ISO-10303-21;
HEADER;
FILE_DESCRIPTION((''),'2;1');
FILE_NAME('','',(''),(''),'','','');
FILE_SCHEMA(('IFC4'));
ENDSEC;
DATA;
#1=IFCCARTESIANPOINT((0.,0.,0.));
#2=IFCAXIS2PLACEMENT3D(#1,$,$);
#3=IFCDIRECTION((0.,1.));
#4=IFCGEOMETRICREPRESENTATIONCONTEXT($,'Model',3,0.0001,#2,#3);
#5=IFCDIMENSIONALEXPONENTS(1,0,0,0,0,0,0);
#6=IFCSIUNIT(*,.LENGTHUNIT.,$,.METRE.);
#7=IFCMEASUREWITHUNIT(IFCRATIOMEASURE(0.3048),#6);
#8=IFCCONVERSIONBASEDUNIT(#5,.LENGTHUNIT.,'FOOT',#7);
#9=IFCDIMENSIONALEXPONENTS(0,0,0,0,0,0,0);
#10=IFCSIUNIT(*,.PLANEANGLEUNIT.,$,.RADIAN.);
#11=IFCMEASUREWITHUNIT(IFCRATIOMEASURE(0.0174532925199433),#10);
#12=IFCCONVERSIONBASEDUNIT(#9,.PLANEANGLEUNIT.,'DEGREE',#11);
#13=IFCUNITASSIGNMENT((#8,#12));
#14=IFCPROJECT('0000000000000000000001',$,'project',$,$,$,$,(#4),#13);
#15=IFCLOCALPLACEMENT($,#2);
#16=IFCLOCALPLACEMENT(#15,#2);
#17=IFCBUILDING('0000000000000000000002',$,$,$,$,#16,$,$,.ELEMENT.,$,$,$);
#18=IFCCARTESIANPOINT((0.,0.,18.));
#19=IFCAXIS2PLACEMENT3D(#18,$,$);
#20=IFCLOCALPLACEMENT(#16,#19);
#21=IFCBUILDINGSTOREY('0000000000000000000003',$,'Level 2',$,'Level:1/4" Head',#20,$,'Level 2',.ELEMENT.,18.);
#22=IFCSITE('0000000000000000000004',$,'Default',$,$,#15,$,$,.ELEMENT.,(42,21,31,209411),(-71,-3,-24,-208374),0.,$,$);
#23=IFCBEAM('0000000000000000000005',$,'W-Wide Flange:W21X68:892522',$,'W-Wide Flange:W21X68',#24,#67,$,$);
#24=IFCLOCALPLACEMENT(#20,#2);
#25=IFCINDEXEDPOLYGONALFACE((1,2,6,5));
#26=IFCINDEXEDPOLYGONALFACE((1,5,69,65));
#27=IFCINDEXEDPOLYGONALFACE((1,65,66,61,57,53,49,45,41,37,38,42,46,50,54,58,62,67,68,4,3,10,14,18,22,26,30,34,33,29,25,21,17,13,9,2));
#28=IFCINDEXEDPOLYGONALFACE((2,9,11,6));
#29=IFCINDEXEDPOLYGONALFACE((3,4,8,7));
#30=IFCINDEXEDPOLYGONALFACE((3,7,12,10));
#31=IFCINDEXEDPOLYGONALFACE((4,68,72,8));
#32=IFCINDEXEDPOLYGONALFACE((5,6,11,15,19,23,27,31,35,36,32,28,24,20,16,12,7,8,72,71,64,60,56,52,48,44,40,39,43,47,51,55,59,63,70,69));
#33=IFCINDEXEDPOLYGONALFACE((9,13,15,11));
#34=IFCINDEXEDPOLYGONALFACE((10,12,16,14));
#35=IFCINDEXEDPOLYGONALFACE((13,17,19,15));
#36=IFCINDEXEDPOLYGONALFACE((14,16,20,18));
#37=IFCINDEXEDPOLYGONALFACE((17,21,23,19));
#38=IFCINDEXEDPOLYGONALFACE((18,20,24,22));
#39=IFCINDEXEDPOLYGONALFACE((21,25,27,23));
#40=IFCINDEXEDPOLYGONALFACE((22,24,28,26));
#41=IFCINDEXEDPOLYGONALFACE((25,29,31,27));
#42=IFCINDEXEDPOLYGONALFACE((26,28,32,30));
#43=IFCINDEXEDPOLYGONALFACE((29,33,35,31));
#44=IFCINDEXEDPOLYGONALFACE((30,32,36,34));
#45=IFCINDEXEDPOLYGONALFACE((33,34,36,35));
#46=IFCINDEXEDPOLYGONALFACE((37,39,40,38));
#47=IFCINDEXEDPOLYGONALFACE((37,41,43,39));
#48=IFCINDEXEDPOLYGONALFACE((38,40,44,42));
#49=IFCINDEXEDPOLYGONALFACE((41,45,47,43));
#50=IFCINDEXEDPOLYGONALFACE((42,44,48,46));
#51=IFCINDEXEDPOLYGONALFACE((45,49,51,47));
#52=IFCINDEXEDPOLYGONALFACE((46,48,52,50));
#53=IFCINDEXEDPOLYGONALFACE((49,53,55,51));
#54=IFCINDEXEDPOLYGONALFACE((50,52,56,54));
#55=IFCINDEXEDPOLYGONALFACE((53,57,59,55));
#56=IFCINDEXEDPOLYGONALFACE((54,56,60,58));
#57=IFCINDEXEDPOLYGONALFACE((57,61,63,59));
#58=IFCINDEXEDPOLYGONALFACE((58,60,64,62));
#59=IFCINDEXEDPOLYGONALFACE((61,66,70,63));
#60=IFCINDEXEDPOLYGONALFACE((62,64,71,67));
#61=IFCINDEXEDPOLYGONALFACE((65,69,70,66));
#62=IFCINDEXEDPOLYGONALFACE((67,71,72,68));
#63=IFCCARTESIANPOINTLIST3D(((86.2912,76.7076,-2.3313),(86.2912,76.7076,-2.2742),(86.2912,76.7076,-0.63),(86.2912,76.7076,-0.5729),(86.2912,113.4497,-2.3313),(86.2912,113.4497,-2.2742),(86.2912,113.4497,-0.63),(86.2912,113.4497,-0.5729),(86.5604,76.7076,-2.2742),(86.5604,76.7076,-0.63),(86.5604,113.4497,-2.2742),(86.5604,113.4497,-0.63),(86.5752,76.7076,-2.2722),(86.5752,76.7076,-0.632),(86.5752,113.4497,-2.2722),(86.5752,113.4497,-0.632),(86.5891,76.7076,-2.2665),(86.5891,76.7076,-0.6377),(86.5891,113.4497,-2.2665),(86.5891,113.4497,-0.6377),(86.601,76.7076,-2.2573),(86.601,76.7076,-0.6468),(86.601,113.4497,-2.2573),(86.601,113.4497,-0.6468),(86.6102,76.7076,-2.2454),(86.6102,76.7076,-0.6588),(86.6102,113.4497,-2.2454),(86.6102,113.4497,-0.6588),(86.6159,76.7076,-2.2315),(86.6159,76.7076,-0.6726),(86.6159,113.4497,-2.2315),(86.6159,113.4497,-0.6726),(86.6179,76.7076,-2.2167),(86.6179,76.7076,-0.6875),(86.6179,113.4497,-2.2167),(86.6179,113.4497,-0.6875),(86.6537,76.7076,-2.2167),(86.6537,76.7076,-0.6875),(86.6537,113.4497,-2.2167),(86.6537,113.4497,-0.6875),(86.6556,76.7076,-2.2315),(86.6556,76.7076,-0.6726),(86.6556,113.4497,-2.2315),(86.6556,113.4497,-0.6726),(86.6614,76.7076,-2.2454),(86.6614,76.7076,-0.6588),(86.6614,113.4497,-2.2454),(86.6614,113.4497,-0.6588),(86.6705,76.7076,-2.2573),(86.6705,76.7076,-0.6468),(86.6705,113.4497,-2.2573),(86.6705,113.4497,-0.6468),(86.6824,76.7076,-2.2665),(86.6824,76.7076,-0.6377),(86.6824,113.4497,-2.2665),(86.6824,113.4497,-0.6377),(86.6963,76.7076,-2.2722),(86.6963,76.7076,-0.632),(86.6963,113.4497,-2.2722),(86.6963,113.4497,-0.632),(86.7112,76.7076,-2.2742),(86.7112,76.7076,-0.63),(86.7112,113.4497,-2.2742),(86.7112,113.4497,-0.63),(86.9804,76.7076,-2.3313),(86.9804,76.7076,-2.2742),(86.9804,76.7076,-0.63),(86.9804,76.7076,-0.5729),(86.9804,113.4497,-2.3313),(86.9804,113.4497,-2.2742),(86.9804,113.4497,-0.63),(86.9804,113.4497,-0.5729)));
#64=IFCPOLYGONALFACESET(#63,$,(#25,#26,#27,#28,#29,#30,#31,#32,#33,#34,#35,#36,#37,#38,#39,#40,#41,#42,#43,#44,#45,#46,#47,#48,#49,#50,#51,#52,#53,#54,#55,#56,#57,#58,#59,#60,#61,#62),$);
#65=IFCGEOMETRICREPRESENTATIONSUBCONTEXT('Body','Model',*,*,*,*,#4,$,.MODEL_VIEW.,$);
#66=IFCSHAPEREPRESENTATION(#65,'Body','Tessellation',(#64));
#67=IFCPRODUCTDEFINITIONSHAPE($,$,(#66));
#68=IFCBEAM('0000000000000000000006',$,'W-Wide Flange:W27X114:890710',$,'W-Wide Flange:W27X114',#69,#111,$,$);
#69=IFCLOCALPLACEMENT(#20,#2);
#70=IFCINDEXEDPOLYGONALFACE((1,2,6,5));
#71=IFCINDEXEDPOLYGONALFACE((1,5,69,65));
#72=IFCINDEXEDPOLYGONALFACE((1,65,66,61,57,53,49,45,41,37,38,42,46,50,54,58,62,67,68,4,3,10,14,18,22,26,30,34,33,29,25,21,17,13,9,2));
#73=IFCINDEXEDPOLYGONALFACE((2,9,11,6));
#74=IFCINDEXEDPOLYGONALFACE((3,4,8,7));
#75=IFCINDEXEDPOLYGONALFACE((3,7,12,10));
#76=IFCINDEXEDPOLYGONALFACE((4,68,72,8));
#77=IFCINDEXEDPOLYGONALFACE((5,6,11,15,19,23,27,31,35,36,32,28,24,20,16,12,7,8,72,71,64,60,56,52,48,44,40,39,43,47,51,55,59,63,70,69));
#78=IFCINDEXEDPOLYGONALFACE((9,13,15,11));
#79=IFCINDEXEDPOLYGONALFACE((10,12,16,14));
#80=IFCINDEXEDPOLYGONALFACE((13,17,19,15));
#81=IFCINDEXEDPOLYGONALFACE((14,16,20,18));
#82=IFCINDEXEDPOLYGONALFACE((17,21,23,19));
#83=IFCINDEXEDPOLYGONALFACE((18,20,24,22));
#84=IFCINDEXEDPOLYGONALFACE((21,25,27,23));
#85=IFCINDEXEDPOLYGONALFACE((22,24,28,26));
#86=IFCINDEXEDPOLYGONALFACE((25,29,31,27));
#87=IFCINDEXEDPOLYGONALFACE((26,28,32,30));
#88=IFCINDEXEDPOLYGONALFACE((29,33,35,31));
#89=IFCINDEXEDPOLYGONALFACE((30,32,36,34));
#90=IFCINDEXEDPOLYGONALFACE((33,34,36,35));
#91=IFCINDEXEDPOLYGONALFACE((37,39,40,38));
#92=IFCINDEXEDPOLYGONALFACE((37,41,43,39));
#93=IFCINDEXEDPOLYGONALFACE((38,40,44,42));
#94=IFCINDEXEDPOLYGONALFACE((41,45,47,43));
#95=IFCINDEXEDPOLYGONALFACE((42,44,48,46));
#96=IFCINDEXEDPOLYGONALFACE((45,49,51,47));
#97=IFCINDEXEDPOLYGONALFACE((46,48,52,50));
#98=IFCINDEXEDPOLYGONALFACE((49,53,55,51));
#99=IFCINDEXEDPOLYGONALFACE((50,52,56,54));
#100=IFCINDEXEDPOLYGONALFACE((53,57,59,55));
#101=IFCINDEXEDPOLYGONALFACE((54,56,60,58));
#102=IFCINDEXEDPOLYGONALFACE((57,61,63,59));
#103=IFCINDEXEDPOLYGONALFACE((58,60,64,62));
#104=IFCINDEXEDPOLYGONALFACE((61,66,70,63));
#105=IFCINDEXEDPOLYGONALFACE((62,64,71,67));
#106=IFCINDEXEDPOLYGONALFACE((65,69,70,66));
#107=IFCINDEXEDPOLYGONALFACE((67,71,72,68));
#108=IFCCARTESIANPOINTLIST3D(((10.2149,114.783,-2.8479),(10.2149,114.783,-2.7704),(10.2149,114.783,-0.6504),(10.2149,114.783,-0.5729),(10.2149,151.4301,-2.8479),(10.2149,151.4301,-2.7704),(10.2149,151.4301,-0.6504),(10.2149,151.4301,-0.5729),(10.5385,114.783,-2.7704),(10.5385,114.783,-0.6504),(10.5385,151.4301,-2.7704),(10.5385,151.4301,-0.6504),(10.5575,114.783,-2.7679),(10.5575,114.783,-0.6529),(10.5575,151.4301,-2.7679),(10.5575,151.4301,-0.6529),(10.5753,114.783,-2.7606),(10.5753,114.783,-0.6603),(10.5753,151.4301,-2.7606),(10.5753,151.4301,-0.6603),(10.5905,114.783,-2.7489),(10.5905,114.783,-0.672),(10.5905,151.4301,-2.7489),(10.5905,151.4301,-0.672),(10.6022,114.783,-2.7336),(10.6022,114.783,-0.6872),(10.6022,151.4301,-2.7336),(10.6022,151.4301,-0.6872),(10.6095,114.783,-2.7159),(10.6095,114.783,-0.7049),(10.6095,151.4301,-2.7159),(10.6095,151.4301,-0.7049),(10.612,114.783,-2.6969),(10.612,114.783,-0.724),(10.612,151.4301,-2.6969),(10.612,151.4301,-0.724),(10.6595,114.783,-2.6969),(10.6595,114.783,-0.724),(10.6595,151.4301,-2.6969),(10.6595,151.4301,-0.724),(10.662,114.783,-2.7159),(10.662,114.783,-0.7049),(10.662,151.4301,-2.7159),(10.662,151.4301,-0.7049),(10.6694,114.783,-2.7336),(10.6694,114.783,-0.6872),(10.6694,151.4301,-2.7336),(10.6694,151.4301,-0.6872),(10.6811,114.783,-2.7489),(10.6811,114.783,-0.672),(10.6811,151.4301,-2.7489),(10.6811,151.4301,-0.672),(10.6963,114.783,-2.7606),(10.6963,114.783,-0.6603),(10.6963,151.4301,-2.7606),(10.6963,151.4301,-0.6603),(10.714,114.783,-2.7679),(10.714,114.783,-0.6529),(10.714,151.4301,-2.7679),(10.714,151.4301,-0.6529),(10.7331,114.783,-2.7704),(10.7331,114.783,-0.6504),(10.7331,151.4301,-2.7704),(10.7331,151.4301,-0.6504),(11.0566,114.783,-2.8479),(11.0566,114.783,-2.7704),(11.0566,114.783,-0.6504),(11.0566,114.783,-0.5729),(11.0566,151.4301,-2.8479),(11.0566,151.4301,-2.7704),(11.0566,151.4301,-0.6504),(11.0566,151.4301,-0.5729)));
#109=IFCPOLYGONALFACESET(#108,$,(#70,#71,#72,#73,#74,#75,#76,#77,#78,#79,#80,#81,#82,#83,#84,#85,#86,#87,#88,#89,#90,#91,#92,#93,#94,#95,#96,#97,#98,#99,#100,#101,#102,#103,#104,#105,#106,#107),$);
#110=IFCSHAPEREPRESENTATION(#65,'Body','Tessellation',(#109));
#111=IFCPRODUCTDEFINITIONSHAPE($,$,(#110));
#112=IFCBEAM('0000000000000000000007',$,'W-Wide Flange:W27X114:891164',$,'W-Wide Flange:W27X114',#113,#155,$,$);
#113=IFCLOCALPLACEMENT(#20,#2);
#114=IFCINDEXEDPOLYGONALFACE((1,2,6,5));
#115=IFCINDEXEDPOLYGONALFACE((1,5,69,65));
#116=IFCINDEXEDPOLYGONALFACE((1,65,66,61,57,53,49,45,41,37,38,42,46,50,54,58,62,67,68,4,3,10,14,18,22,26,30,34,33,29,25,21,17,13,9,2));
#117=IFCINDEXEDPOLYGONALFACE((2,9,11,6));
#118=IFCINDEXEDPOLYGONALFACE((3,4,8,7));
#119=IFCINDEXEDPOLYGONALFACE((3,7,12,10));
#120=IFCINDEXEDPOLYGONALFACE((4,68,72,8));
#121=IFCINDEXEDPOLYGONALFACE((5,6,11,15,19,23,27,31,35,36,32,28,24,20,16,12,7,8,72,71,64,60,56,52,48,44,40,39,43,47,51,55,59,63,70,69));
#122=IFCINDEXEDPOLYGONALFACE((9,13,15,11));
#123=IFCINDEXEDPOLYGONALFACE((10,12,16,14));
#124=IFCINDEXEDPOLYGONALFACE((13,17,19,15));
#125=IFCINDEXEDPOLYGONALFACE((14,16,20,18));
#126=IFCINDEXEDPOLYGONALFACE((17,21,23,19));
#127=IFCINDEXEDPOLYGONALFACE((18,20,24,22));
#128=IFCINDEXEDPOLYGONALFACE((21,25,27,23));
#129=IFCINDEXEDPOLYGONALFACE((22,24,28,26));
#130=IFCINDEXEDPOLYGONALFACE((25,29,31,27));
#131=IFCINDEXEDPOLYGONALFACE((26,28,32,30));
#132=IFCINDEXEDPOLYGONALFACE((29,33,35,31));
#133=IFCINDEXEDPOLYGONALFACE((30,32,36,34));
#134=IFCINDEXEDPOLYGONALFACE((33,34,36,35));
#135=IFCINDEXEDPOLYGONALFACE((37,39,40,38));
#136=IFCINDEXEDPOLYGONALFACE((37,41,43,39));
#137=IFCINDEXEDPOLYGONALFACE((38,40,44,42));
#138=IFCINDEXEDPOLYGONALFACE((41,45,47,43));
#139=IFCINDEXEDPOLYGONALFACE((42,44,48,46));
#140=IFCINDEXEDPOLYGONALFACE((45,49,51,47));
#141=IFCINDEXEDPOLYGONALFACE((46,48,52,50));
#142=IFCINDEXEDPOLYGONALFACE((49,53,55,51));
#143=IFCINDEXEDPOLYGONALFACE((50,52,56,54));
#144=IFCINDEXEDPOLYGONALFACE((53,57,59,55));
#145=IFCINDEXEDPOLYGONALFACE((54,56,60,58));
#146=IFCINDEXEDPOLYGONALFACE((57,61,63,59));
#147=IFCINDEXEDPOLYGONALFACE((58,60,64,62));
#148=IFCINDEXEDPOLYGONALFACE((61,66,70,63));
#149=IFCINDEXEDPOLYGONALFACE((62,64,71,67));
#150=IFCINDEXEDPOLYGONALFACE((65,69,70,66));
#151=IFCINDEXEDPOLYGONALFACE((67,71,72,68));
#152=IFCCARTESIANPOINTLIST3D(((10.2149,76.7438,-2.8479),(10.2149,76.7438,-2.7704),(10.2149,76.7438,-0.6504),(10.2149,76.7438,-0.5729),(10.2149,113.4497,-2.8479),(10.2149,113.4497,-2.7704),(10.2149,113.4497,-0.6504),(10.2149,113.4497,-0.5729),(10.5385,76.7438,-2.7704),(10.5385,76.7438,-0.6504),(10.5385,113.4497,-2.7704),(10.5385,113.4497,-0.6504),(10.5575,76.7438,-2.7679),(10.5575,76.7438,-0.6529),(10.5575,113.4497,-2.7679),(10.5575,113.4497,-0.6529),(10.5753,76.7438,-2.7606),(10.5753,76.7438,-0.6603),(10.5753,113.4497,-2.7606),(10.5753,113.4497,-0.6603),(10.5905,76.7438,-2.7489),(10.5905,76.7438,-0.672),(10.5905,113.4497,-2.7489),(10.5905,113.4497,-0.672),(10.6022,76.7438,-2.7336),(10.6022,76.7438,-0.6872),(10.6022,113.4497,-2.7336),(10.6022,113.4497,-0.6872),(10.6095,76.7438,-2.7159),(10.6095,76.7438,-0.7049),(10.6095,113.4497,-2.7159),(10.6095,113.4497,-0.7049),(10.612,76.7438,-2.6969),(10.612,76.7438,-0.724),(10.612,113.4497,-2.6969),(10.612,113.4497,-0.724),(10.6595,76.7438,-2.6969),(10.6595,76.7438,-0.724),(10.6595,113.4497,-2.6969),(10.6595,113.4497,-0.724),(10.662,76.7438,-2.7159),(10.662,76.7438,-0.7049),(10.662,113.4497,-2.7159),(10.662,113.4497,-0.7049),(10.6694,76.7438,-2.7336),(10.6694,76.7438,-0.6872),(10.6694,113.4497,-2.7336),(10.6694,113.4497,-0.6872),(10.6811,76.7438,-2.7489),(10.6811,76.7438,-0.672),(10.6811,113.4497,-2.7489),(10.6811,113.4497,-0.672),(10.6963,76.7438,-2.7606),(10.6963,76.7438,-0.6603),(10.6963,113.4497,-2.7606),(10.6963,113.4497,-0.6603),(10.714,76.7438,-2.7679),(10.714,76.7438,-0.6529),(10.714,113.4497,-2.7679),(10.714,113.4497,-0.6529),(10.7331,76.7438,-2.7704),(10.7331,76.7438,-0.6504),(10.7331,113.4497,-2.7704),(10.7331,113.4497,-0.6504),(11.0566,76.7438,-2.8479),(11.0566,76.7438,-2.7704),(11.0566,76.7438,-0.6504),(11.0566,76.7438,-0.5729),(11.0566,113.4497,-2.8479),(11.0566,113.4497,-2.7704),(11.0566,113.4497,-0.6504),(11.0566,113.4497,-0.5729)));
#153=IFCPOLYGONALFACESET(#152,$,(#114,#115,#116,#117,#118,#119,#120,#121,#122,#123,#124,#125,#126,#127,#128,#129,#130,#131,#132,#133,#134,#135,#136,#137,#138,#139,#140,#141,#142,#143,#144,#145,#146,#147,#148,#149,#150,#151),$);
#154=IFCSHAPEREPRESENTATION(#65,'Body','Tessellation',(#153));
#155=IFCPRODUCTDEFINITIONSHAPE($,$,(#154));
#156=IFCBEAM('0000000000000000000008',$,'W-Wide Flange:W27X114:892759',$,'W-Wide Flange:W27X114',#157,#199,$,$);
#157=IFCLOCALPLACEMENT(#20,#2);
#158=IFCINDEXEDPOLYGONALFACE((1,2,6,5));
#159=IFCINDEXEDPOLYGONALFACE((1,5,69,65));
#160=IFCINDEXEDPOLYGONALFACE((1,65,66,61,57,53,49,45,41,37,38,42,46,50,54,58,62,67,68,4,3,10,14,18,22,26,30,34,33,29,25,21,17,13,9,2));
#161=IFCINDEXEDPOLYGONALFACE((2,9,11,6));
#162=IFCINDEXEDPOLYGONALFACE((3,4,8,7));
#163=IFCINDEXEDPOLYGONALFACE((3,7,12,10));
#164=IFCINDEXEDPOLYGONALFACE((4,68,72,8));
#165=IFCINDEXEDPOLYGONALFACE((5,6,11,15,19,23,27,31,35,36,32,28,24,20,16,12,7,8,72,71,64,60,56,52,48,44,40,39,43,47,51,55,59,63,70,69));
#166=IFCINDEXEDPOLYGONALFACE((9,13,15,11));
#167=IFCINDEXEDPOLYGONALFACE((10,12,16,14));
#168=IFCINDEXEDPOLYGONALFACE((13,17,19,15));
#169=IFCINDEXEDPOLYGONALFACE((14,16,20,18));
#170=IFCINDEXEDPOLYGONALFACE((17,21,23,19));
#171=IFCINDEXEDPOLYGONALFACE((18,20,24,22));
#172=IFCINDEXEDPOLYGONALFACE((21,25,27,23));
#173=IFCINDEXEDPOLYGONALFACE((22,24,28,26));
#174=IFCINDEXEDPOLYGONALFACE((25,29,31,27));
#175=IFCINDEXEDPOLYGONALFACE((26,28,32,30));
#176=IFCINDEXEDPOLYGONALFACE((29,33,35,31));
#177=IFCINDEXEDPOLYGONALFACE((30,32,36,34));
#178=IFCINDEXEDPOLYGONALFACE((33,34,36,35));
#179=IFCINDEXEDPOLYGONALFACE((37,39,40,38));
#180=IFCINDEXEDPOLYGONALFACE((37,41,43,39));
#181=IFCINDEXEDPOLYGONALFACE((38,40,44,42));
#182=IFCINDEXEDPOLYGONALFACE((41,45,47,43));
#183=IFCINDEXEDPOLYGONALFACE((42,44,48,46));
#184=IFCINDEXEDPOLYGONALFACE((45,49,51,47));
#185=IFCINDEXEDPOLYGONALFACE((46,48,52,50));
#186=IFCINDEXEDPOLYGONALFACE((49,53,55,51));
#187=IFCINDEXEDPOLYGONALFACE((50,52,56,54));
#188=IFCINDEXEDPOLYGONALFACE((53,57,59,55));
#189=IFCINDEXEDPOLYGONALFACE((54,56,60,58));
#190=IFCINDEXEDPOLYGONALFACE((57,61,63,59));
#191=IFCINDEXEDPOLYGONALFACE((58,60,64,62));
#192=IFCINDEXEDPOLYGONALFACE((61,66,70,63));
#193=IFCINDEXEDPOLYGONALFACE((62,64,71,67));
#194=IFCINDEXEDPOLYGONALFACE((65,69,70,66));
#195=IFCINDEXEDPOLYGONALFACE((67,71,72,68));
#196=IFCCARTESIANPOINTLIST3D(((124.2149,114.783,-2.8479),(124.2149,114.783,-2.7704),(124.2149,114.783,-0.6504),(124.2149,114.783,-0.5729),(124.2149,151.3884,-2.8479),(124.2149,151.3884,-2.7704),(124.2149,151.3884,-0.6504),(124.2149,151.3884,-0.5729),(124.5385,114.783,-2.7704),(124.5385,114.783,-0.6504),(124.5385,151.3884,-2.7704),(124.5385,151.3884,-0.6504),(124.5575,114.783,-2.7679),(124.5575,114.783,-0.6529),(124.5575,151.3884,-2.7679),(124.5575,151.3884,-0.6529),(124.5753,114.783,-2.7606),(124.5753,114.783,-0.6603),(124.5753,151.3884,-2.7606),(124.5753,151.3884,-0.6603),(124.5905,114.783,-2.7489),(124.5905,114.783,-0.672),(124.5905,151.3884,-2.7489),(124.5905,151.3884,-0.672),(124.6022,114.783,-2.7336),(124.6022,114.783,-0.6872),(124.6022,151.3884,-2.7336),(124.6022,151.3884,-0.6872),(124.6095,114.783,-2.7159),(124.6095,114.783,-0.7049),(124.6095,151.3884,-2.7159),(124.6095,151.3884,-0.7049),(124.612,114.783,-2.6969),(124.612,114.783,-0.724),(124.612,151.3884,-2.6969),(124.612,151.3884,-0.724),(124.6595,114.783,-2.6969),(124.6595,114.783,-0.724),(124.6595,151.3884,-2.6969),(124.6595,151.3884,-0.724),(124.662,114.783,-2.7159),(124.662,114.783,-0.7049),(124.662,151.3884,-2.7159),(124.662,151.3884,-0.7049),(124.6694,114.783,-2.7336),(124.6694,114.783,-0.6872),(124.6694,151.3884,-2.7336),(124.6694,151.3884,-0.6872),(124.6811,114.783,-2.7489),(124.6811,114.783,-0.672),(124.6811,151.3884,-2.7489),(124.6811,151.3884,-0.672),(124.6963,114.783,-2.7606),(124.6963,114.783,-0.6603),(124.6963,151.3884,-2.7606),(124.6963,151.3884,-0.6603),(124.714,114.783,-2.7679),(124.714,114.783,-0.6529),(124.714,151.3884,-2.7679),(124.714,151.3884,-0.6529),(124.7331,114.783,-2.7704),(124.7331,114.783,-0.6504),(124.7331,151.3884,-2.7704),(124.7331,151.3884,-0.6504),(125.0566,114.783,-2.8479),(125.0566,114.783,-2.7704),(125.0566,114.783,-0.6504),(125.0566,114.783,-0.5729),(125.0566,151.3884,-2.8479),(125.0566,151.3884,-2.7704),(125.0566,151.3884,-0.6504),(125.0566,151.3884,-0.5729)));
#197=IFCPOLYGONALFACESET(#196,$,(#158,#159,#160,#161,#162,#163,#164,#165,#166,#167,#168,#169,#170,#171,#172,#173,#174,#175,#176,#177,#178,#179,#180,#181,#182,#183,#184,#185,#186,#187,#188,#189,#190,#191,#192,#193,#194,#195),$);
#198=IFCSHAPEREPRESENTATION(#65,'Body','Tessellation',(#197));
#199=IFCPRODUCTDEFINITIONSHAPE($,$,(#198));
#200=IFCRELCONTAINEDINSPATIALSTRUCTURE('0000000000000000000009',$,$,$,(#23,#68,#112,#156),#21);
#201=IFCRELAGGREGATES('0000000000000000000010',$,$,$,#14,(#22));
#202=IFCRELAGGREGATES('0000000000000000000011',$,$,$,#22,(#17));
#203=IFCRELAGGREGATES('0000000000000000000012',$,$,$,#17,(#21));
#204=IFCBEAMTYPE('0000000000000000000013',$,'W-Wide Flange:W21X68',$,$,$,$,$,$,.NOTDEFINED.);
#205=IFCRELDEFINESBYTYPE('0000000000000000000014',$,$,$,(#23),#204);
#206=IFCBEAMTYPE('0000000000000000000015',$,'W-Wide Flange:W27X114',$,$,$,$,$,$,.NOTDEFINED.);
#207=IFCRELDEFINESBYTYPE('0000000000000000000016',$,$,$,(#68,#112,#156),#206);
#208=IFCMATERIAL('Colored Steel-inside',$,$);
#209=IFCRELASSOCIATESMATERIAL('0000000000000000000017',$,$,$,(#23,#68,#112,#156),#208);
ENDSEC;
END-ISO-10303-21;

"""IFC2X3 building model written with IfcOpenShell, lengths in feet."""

from ifc_helpers import new_model, entity, si_unit, converted_unit, direction, frame, frame_2d, origin, place, context, subcontext, project, spatial, i_section, extrude, material, type_object, element, save


model = new_model("IFC2X3")

# Units and contexts
model_context = context("Model", 3, precision=0.0001, world=origin(), true_north=direction((0.0, 1.0)))
body_context = subcontext(model_context, "Body", "Model", "MODEL_VIEW")
ifc_project = project(units=[converted_unit("LENGTHUNIT", "FOOT", entity("IfcRatioMeasure", 0.3048), si_unit("LENGTHUNIT", "METRE"), dimensions=[1, 0, 0, 0, 0, 0, 0]), converted_unit("PLANEANGLEUNIT", "DEGREE", entity("IfcRatioMeasure", 0.0174532925199433), si_unit("PLANEANGLEUNIT", "RADIAN"), dimensions=[0, 0, 0, 0, 0, 0, 0])], contexts=[model_context])

# Site, building, storey
site_placement = place(None, origin())
site = spatial("IfcSite", under=ifc_project, at=site_placement, Name="Default", CompositionType="ELEMENT", RefLatitude=(42, 21, 31, 209411), RefLongitude=(-71, -3, -24, -208374), RefElevation=0.0)
building_placement = place(site_placement, origin())
building = spatial("IfcBuilding", under=site, at=building_placement, CompositionType="ELEMENT")
storey_placement = place(building_placement, frame((0.0, 0.0, 18.0)))
storey = spatial("IfcBuildingStorey", under=building, at=storey_placement, Name="Level 2", ObjectType="Level:1/4\" Head", LongName="Level 2", CompositionType="ELEMENT", Elevation=18.0)

# Shared definitions
ifc_material_1 = material(Name="Colored Steel-inside")

# Beams
beam_type_1 = type_object("IfcBeamType", Name="W-Wide Flange:W21X68", PredefinedType="NOTDEFINED")
beam_1_placement = place(storey_placement, frame((86.6358, 114.0968, 0.0), z_axis=(0.0, 0.0, 1.0), x_axis=(0.0, -1.0, 0.0)))
element("IfcBeam", 1, at=beam_1_placement, inside=storey, type_object=beam_type_1, material=ifc_material_1, Name="W-Wide Flange:W21X68:892522", ObjectType="W-Wide Flange:W21X68", context=body_context, shape_type="SweptSolid", body=[
    extrude(i_section(OverallWidth=0.6892, OverallDepth=1.7583, WebThickness=0.0358, FlangeThickness=0.0571, FilletRadius=0.0575, at=frame_2d((0.0, 0.0), x_axis=(0.0, 1.0))), frame((0.6471, 0.0, -1.4521), z_axis=(1.0, 0.0, 0.0), x_axis=(0.0, 0.0, -1.0)), (0.0, 0.0, 1.0), 36.7421),
])
beam_type_2 = type_object("IfcBeamType", Name="W-Wide Flange:W27X114", PredefinedType="NOTDEFINED")
beam_2_placement = place(storey_placement, frame((10.6358, 152.0968, 0.0), z_axis=(0.0, 0.0, 1.0), x_axis=(0.0, -1.0, 0.0)))
element("IfcBeam", 2, at=beam_2_placement, inside=storey, type_object=beam_type_2, material=ifc_material_1, Name="W-Wide Flange:W27X114:890710", ObjectType="W-Wide Flange:W27X114", context=body_context, shape_type="SweptSolid", body=[
    extrude(i_section(OverallWidth=0.8417, OverallDepth=2.275, WebThickness=0.0475, FlangeThickness=0.0775, FilletRadius=0.0735, at=frame_2d((0.0, 0.0), x_axis=(0.0, 1.0))), frame((0.6667, 0.0, -1.7104), z_axis=(1.0, 0.0, 0.0), x_axis=(0.0, 0.0, -1.0)), (0.0, 0.0, 1.0), 36.6471),
])
beam_3_placement = place(storey_placement, frame((10.6358, 114.0968, 0.0), z_axis=(0.0, 0.0, 1.0), x_axis=(0.0, -1.0, 0.0)))
element("IfcBeam", 3, at=beam_3_placement, inside=storey, type_object=beam_type_2, material=ifc_material_1, Name="W-Wide Flange:W27X114:891164", ObjectType="W-Wide Flange:W27X114", context=body_context, shape_type="SweptSolid", body=[
    extrude(i_section(OverallWidth=0.8417, OverallDepth=2.275, WebThickness=0.0475, FlangeThickness=0.0775, FilletRadius=0.0735, at=frame_2d((0.0, 0.0), x_axis=(0.0, 1.0))), frame((0.6471, 0.0, -1.7104), z_axis=(1.0, 0.0, 0.0), x_axis=(0.0, 0.0, -1.0)), (0.0, 0.0, 1.0), 36.7058),
])
beam_4_placement = place(storey_placement, frame((124.6358, 152.0968, 0.0), z_axis=(0.0, 0.0, 1.0), x_axis=(0.0, -1.0, 0.0)))
element("IfcBeam", 4, at=beam_4_placement, inside=storey, type_object=beam_type_2, material=ifc_material_1, Name="W-Wide Flange:W27X114:892759", ObjectType="W-Wide Flange:W27X114", context=body_context, shape_type="SweptSolid", body=[
    extrude(i_section(OverallWidth=0.8417, OverallDepth=2.275, WebThickness=0.0475, FlangeThickness=0.0775, FilletRadius=0.0735, at=frame_2d((0.0, 0.0), x_axis=(0.0, 1.0))), frame((0.7083, 0.0, -1.7104), z_axis=(1.0, 0.0, 0.0), x_axis=(0.0, 0.0, -1.0)), (0.0, 0.0, 1.0), 36.6054),
])

save(model, "model.ifc")
